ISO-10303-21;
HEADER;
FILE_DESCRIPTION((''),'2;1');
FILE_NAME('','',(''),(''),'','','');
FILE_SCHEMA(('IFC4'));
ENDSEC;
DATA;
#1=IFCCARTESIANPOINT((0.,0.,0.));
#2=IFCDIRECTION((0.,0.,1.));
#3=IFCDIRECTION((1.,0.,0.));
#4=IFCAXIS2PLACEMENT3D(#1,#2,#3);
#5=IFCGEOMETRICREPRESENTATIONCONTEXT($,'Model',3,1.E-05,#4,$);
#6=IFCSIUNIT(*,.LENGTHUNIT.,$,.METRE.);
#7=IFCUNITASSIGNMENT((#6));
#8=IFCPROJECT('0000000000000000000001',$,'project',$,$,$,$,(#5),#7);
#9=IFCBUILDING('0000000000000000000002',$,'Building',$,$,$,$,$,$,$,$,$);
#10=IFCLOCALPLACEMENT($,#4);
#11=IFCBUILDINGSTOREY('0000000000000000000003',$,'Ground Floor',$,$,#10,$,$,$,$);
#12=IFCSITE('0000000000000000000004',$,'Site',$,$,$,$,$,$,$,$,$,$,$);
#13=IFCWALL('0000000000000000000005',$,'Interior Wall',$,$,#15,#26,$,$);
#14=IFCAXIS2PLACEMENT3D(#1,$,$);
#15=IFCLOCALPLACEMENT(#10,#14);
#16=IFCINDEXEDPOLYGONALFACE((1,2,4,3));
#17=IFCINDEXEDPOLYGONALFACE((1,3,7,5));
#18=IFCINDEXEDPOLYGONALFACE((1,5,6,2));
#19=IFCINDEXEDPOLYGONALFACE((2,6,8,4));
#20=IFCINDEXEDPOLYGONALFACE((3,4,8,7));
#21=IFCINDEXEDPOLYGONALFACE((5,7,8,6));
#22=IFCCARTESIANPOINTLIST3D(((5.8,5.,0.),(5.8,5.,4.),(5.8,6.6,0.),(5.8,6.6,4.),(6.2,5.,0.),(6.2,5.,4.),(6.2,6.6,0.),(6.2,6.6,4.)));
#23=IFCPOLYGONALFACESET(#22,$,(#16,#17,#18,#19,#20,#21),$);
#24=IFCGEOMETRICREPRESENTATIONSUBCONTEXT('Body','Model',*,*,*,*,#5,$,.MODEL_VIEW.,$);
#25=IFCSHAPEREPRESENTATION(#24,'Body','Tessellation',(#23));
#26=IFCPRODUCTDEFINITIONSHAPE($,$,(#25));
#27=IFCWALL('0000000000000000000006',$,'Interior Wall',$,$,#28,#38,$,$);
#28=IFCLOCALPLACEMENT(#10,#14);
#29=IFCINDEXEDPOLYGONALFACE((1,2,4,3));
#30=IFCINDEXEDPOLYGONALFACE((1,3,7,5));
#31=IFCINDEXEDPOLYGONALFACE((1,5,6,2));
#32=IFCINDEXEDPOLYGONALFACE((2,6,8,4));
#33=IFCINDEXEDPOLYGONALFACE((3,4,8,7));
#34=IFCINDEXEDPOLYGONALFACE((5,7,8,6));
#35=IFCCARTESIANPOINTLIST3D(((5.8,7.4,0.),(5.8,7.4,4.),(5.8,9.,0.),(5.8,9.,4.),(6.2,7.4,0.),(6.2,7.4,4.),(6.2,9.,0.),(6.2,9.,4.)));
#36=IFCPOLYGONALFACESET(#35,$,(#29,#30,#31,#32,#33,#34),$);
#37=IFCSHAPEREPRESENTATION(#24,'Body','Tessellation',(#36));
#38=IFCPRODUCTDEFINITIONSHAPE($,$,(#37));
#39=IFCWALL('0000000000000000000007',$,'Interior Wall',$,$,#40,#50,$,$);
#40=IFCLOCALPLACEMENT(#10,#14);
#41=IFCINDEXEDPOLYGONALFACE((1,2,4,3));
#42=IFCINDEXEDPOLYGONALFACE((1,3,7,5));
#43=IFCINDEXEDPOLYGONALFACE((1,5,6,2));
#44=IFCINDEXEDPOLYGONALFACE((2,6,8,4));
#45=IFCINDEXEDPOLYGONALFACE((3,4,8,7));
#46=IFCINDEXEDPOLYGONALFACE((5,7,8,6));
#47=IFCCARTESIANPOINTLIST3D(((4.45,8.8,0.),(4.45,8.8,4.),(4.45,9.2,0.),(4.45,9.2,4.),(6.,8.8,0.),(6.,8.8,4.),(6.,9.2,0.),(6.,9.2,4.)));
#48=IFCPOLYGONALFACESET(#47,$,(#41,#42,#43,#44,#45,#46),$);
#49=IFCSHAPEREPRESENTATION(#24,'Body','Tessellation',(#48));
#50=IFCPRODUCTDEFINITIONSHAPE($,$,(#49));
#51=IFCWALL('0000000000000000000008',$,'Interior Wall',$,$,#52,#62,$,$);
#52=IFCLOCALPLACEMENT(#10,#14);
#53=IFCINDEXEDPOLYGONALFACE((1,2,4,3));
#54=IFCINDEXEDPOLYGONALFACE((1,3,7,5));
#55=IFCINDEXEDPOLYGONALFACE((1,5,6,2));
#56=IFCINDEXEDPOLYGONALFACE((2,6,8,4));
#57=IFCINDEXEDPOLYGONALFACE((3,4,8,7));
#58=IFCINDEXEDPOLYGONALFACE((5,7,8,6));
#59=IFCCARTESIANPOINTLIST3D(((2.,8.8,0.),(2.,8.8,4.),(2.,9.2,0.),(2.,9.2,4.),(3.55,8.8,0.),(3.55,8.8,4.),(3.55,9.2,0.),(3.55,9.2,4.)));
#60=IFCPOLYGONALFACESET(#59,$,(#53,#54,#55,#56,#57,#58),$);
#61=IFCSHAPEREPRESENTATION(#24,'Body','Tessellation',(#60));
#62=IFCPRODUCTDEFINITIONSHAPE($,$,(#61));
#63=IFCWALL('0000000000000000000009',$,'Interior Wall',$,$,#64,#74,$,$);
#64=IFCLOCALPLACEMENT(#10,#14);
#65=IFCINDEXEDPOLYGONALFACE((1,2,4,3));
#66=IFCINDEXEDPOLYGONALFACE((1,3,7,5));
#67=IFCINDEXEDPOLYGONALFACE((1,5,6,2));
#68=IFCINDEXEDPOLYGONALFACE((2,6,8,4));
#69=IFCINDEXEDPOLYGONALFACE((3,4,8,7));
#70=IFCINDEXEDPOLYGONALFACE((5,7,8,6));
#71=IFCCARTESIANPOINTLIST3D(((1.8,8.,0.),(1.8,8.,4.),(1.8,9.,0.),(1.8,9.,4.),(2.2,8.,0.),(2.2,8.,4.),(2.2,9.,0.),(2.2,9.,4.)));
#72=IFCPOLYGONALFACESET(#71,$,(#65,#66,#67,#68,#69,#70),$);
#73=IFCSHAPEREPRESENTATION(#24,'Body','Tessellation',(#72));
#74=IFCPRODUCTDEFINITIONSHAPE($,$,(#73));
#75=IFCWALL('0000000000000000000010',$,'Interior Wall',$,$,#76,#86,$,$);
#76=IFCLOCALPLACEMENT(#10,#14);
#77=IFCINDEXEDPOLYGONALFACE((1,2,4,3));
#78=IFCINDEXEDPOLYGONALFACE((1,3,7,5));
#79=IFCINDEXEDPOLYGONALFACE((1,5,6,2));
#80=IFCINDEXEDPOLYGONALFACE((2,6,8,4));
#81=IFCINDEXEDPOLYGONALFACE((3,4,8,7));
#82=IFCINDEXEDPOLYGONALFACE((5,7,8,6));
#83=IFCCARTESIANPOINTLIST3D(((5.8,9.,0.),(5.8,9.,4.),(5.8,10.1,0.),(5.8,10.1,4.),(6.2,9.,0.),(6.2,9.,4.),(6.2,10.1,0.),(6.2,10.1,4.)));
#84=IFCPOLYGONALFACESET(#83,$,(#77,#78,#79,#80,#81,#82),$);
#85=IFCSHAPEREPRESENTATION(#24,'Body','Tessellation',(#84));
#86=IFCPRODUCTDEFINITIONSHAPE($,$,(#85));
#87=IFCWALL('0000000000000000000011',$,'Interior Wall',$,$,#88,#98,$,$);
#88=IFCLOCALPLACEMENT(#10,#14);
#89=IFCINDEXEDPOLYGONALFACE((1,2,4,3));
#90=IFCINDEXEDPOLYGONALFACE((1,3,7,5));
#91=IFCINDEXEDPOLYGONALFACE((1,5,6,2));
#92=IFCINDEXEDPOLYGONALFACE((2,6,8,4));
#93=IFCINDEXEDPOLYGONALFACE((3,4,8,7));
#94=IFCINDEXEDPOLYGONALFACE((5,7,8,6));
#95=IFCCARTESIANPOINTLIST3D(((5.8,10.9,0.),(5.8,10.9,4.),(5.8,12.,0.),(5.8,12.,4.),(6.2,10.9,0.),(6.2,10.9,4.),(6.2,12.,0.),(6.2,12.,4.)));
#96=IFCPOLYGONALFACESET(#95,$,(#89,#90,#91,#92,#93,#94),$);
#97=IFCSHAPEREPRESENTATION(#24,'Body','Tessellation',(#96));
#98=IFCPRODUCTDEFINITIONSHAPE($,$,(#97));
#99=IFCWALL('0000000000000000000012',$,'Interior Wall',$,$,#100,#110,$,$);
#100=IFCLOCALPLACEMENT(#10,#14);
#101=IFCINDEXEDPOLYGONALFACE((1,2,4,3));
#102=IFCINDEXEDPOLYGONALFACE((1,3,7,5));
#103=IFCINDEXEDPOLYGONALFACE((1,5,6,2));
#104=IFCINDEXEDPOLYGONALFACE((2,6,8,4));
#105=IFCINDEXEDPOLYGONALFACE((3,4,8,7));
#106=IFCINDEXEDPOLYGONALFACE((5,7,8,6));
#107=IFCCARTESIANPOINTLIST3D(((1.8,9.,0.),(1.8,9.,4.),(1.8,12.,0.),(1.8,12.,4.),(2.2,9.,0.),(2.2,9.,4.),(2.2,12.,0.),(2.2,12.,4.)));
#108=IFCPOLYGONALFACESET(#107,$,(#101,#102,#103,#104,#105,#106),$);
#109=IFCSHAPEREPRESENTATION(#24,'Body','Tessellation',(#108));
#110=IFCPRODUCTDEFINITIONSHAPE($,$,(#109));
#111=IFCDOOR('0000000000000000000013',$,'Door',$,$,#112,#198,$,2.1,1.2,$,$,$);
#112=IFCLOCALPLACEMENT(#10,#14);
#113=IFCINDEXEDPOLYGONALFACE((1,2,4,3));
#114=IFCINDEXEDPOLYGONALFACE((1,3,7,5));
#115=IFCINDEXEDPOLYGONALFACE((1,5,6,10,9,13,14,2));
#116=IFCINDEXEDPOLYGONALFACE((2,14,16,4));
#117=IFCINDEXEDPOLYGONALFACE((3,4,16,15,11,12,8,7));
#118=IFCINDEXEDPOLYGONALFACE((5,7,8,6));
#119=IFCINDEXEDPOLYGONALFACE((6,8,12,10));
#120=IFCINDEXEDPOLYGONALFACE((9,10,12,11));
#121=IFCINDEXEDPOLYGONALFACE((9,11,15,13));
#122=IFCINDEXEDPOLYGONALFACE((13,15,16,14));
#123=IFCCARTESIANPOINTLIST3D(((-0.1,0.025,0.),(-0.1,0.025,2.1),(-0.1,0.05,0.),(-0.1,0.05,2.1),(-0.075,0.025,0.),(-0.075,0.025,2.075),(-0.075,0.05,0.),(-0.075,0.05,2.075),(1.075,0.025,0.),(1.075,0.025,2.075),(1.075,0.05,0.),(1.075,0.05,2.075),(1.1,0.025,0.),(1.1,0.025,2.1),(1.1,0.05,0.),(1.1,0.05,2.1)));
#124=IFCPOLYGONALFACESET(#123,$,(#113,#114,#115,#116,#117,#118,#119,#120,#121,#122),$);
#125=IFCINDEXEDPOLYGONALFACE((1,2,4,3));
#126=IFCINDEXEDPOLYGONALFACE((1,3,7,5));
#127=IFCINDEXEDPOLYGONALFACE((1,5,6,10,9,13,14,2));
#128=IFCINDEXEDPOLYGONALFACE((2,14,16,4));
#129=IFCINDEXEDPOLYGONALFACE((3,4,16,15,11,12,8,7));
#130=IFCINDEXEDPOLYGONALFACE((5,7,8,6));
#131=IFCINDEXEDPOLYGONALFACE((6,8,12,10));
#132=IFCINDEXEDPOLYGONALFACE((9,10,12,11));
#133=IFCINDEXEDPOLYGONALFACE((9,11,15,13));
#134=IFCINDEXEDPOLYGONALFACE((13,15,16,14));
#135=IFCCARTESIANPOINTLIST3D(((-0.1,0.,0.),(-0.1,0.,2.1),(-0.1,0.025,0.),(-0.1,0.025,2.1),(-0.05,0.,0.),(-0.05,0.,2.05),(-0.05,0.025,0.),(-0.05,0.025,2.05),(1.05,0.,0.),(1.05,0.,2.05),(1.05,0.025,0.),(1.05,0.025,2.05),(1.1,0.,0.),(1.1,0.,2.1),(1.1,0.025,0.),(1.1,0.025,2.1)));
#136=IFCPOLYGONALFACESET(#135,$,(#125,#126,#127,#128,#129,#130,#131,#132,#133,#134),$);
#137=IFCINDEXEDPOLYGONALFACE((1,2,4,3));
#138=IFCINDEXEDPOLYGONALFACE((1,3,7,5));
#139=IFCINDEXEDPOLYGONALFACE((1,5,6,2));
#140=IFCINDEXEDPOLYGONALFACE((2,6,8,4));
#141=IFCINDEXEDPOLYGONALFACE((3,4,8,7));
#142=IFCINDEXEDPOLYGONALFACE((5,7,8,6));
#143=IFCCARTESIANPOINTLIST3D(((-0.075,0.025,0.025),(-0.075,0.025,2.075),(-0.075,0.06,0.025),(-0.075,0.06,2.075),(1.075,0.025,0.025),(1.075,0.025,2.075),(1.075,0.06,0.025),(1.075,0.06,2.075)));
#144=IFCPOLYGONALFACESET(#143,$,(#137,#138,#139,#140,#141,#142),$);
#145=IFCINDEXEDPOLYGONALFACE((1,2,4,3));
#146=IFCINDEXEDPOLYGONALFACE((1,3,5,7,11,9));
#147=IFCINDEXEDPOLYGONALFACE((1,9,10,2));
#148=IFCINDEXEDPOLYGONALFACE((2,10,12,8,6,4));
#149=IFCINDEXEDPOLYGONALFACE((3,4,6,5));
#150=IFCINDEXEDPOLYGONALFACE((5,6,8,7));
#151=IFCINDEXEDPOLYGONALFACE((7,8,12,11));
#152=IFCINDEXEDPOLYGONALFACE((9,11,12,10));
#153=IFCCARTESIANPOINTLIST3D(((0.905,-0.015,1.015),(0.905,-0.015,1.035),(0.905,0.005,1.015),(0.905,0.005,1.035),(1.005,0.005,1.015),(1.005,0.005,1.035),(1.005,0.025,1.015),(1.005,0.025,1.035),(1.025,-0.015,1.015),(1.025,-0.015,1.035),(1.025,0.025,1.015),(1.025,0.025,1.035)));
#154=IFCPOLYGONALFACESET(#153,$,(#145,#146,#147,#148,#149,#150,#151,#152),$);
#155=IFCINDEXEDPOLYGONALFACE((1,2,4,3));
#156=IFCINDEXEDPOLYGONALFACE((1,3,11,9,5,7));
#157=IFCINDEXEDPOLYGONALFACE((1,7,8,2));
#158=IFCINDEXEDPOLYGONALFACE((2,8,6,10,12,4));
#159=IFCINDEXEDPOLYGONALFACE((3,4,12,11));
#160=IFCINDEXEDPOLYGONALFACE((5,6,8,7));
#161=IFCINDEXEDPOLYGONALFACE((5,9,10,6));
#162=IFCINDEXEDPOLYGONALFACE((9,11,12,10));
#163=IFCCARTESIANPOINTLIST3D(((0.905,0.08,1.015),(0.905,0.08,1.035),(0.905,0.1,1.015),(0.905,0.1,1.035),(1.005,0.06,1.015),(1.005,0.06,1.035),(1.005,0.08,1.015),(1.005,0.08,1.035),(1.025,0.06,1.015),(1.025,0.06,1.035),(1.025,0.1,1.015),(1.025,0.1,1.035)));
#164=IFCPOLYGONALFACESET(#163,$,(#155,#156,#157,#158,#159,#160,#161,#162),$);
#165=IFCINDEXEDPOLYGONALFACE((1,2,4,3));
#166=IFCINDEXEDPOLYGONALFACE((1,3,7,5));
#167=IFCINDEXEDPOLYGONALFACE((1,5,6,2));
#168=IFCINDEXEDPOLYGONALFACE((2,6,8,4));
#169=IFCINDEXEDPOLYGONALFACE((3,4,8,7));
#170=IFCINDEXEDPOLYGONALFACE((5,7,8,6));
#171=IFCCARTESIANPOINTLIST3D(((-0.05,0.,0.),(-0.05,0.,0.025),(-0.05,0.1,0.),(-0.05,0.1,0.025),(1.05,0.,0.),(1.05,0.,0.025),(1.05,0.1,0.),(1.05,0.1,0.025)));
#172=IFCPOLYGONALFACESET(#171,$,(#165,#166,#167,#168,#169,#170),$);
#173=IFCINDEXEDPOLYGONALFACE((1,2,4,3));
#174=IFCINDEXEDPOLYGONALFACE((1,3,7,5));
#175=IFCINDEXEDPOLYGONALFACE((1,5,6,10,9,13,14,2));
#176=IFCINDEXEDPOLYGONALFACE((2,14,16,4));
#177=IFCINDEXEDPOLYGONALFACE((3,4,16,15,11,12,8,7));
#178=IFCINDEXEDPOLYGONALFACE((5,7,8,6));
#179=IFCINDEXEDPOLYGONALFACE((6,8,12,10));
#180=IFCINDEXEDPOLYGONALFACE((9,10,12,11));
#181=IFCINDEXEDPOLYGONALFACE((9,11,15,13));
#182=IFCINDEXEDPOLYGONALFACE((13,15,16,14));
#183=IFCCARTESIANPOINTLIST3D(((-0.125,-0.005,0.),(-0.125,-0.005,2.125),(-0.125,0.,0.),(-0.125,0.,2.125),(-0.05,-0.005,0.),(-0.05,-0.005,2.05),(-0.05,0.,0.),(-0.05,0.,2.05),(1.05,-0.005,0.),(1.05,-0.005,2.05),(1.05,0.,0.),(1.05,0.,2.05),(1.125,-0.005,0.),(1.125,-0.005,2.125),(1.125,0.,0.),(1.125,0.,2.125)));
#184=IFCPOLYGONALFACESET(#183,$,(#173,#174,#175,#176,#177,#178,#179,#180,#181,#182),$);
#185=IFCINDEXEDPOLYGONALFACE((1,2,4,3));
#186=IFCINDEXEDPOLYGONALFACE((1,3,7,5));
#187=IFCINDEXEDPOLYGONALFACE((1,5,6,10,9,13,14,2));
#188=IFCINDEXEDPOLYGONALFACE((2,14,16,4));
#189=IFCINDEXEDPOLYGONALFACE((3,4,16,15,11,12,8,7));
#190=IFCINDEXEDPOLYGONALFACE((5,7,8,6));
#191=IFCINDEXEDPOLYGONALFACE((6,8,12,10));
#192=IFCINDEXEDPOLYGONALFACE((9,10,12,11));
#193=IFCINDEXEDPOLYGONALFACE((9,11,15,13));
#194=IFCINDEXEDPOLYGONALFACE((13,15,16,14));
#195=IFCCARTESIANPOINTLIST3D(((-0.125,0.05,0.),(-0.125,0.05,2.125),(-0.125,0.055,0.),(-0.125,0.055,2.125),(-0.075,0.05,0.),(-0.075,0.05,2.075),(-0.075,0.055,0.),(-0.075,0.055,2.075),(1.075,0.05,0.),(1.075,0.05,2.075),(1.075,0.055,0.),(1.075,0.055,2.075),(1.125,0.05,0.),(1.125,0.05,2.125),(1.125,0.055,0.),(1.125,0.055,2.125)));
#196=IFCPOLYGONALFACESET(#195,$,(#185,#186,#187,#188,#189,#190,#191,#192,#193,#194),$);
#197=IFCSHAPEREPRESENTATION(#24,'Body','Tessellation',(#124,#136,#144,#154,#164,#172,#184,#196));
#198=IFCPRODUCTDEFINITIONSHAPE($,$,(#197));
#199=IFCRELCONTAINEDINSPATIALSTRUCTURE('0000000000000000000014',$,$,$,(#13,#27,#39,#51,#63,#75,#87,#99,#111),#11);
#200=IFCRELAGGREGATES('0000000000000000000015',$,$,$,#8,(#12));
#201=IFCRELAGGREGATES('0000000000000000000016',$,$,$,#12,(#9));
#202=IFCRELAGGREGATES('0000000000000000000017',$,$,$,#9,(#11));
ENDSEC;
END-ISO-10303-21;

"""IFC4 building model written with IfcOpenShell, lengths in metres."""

from ifc_helpers import new_model, si_unit, frame, origin_with_axes, place, context, subcontext, project, spatial, line, indexed_curve, outline, extrude, element, save


model = new_model("IFC4")

# Units and contexts
model_context = context("Model", 3, precision=1e-05, world=origin_with_axes())
body_context = subcontext(model_context, "Body", "Model", "MODEL_VIEW")
ifc_project = project(units=[si_unit("LENGTHUNIT", "METRE")], contexts=[model_context])

# Site, building, storey
site = spatial("IfcSite", under=ifc_project, Name="Site")
building = spatial("IfcBuilding", under=site, Name="Building")
storey_placement = place(None, origin_with_axes())
storey = spatial("IfcBuildingStorey", under=building, at=storey_placement, Name="Ground Floor")

# Walls
for number, where, z_axis, x_axis, name in (
    (1, (6.0, 5.0, 0.0), (0.0, 0.0, 1.0), (0.0, 1.0, 0.0), "Interior Wall"),
    (2, (6.0, 7.4, 0.0), (0.0, 0.0, 1.0), (0.0, 1.0, 0.0), "Interior Wall"),
):
    element("IfcWall", number, at=place(storey_placement, frame(where, z_axis=z_axis, x_axis=x_axis)), inside=storey, Name=name, context=body_context, shape_type="SweptSolid", body=[
        extrude(outline(indexed_curve([(0.0, 0.0), (0.0, 0.4), (1.6, 0.4), (1.6, 0.0), (0.0, 0.0)], self_intersect=False)), frame((0.0, -0.2, 0.0), z_axis=(0.0, 0.0, 1.0), x_axis=(1.0, 0.0, 0.0)), (0.0, 0.0, 1.0), 4.0),
    ])
for number, where, z_axis, x_axis, name in (
    (3, (6.0, 9.0, 0.0), (0.0, 0.0, 1.0), (-1.0, 0.0, 0.0), "Interior Wall"),
    (4, (3.55, 9.0, 0.0), (0.0, 0.0, 1.0), (-1.0, 0.0, 0.0), "Interior Wall"),
):
    element("IfcWall", number, at=place(storey_placement, frame(where, z_axis=z_axis, x_axis=x_axis)), inside=storey, Name=name, context=body_context, shape_type="SweptSolid", body=[
        extrude(outline(indexed_curve([(0.0, 0.0), (0.0, 0.4), (1.55, 0.4), (1.55, 0.0), (0.0, 0.0)], self_intersect=False)), frame((0.0, -0.2, 0.0), z_axis=(0.0, 0.0, 1.0), x_axis=(1.0, 0.0, 0.0)), (0.0, 0.0, 1.0), 4.0),
    ])
wall_1_placement = place(storey_placement, frame((2.0, 9.0, 0.0), z_axis=(0.0, 0.0, 1.0), x_axis=(0.0, -1.0, 0.0)))
element("IfcWall", 5, at=wall_1_placement, inside=storey, Name="Interior Wall", context=body_context, shape_type="SweptSolid", body=[
    extrude(outline(indexed_curve([(0.0, 0.0), (0.0, 0.4), (1.0, 0.4), (1.0, 0.0), (0.0, 0.0)], self_intersect=False)), frame((0.0, -0.2, 0.0), z_axis=(0.0, 0.0, 1.0), x_axis=(1.0, 0.0, 0.0)), (0.0, 0.0, 1.0), 4.0),
])
for number, where, z_axis, x_axis, name in (
    (6, (6.0, 9.0, 0.0), (0.0, 0.0, 1.0), (0.0, 1.0, 0.0), "Interior Wall"),
    (7, (6.0, 10.9, 0.0), (0.0, 0.0, 1.0), (0.0, 1.0, 0.0), "Interior Wall"),
):
    element("IfcWall", number, at=place(storey_placement, frame(where, z_axis=z_axis, x_axis=x_axis)), inside=storey, Name=name, context=body_context, shape_type="SweptSolid", body=[
        extrude(outline(indexed_curve([(0.0, 0.0), (0.0, 0.4), (1.1, 0.4), (1.1, 0.0), (0.0, 0.0)], self_intersect=False)), frame((0.0, -0.2, 0.0), z_axis=(0.0, 0.0, 1.0), x_axis=(1.0, 0.0, 0.0)), (0.0, 0.0, 1.0), 4.0),
    ])
wall_2_placement = place(storey_placement, frame((2.0, 12.0, 0.0), z_axis=(0.0, 0.0, 1.0), x_axis=(0.0, -1.0, 0.0)))
element("IfcWall", 8, at=wall_2_placement, inside=storey, Name="Interior Wall", context=body_context, shape_type="SweptSolid", body=[
    extrude(outline(indexed_curve([(0.0, 0.0), (0.0, 0.4), (3.0, 0.4), (3.0, 0.0), (0.0, 0.0)], self_intersect=False)), frame((0.0, -0.2, 0.0), z_axis=(0.0, 0.0, 1.0), x_axis=(1.0, 0.0, 0.0)), (0.0, 0.0, 1.0), 4.0),
])

# Door
door_1_placement = place(storey_placement, frame((-0.1, 0.0, 0.0), z_axis=(0.0, 0.0, 1.0), x_axis=(1.0, 0.0, 0.0)))
element("IfcDoor", 9, at=door_1_placement, inside=storey, Name="Door", OverallHeight=2.1, OverallWidth=1.2, context=body_context, shape_type="SweptSolid", body=[
    extrude(outline(indexed_curve([(0.0, 0.0), (0.0, 2.1), (1.2, 2.1), (1.2, 0.0), (1.175, 0.0), (1.175, 2.075), (0.025, 2.075), (0.025, 0.0)], segments=[line(1, 2, 3, 4, 5, 6, 7, 8, 1)])), frame((0.0, 0.025, 0.0), z_axis=(0.0, -1.0, 0.0), x_axis=(1.0, 0.0, 0.0)), (0.0, 0.0, -1.0), 0.025),
    extrude(outline(indexed_curve([(0.0, 0.0), (0.0, 2.1), (1.2, 2.1), (1.2, 0.0), (1.15, 0.0), (1.15, 2.05), (0.05, 2.05), (0.05, 0.0)], segments=[line(1, 2, 3, 4, 5, 6, 7, 8, 1)])), frame((0.0, 0.0, 0.0), z_axis=(0.0, -1.0, 0.0), x_axis=(1.0, 0.0, 0.0)), (0.0, 0.0, -1.0), 0.025),
    extrude(outline(indexed_curve([(0.0, 0.0), (1.15, 0.0), (1.15, 0.035), (0.0, 0.035)], segments=[line(1, 2, 3, 4, 1)])), frame((0.025, 0.025, 0.025), z_axis=(0.0, 0.0, 1.0), x_axis=(1.0, 0.0, 0.0)), (0.0, 0.0, 1.0), 2.05),
    extrude(outline(indexed_curve([(0.0, 0.0), (0.0, -0.04), (-0.12, -0.04), (-0.12, -0.02), (-0.02, -0.02), (-0.02, 0.0)], segments=[line(1, 2, 3, 4, 5, 6, 1)])), frame((1.125, 0.025, 1.015), z_axis=(0.0, 0.0, 1.0), x_axis=(1.0, 0.0, 0.0)), (0.0, 0.0, 1.0), 0.02),
    extrude(outline(indexed_curve([(0.0, 0.0), (0.0, 0.04), (-0.12, 0.04), (-0.12, 0.02), (-0.02, 0.02), (-0.02, 0.0)], segments=[line(1, 2, 3, 4, 5, 6, 1)])), frame((1.125, 0.06, 1.015), z_axis=(0.0, 0.0, 1.0), x_axis=(1.0, 0.0, 0.0)), (0.0, 0.0, 1.0), 0.02),
    extrude(outline(indexed_curve([(0.0, 0.0), (1.1, 0.0), (1.1, 0.1), (0.0, 0.1)], segments=[line(1, 2, 3, 4, 1)])), frame((0.05, 0.0, 0.0), z_axis=(0.0, 0.0, 1.0), x_axis=(1.0, 0.0, 0.0)), (0.0, 0.0, 1.0), 0.025),
    extrude(outline(indexed_curve([(0.0, 0.0), (0.0, 2.125), (1.25, 2.125), (1.25, 0.0), (1.175, 0.0), (1.175, 2.05), (0.075, 2.05), (0.075, 0.0)], segments=[line(1, 2, 3, 4, 5, 6, 7, 8, 1)])), frame((-0.025, -0.005, 0.0), z_axis=(0.0, -1.0, 0.0), x_axis=(1.0, 0.0, 0.0)), (0.0, 0.0, -1.0), 0.005),
    extrude(outline(indexed_curve([(0.0, 0.0), (0.0, 2.125), (1.25, 2.125), (1.25, 0.0), (1.2, 0.0), (1.2, 2.075), (0.05, 2.075), (0.05, 0.0)], segments=[line(1, 2, 3, 4, 5, 6, 7, 8, 1)])), frame((-0.025, 0.05, 0.0), z_axis=(0.0, -1.0, 0.0), x_axis=(1.0, 0.0, 0.0)), (0.0, 0.0, -1.0), 0.005),
])

save(model, "model.ifc")
